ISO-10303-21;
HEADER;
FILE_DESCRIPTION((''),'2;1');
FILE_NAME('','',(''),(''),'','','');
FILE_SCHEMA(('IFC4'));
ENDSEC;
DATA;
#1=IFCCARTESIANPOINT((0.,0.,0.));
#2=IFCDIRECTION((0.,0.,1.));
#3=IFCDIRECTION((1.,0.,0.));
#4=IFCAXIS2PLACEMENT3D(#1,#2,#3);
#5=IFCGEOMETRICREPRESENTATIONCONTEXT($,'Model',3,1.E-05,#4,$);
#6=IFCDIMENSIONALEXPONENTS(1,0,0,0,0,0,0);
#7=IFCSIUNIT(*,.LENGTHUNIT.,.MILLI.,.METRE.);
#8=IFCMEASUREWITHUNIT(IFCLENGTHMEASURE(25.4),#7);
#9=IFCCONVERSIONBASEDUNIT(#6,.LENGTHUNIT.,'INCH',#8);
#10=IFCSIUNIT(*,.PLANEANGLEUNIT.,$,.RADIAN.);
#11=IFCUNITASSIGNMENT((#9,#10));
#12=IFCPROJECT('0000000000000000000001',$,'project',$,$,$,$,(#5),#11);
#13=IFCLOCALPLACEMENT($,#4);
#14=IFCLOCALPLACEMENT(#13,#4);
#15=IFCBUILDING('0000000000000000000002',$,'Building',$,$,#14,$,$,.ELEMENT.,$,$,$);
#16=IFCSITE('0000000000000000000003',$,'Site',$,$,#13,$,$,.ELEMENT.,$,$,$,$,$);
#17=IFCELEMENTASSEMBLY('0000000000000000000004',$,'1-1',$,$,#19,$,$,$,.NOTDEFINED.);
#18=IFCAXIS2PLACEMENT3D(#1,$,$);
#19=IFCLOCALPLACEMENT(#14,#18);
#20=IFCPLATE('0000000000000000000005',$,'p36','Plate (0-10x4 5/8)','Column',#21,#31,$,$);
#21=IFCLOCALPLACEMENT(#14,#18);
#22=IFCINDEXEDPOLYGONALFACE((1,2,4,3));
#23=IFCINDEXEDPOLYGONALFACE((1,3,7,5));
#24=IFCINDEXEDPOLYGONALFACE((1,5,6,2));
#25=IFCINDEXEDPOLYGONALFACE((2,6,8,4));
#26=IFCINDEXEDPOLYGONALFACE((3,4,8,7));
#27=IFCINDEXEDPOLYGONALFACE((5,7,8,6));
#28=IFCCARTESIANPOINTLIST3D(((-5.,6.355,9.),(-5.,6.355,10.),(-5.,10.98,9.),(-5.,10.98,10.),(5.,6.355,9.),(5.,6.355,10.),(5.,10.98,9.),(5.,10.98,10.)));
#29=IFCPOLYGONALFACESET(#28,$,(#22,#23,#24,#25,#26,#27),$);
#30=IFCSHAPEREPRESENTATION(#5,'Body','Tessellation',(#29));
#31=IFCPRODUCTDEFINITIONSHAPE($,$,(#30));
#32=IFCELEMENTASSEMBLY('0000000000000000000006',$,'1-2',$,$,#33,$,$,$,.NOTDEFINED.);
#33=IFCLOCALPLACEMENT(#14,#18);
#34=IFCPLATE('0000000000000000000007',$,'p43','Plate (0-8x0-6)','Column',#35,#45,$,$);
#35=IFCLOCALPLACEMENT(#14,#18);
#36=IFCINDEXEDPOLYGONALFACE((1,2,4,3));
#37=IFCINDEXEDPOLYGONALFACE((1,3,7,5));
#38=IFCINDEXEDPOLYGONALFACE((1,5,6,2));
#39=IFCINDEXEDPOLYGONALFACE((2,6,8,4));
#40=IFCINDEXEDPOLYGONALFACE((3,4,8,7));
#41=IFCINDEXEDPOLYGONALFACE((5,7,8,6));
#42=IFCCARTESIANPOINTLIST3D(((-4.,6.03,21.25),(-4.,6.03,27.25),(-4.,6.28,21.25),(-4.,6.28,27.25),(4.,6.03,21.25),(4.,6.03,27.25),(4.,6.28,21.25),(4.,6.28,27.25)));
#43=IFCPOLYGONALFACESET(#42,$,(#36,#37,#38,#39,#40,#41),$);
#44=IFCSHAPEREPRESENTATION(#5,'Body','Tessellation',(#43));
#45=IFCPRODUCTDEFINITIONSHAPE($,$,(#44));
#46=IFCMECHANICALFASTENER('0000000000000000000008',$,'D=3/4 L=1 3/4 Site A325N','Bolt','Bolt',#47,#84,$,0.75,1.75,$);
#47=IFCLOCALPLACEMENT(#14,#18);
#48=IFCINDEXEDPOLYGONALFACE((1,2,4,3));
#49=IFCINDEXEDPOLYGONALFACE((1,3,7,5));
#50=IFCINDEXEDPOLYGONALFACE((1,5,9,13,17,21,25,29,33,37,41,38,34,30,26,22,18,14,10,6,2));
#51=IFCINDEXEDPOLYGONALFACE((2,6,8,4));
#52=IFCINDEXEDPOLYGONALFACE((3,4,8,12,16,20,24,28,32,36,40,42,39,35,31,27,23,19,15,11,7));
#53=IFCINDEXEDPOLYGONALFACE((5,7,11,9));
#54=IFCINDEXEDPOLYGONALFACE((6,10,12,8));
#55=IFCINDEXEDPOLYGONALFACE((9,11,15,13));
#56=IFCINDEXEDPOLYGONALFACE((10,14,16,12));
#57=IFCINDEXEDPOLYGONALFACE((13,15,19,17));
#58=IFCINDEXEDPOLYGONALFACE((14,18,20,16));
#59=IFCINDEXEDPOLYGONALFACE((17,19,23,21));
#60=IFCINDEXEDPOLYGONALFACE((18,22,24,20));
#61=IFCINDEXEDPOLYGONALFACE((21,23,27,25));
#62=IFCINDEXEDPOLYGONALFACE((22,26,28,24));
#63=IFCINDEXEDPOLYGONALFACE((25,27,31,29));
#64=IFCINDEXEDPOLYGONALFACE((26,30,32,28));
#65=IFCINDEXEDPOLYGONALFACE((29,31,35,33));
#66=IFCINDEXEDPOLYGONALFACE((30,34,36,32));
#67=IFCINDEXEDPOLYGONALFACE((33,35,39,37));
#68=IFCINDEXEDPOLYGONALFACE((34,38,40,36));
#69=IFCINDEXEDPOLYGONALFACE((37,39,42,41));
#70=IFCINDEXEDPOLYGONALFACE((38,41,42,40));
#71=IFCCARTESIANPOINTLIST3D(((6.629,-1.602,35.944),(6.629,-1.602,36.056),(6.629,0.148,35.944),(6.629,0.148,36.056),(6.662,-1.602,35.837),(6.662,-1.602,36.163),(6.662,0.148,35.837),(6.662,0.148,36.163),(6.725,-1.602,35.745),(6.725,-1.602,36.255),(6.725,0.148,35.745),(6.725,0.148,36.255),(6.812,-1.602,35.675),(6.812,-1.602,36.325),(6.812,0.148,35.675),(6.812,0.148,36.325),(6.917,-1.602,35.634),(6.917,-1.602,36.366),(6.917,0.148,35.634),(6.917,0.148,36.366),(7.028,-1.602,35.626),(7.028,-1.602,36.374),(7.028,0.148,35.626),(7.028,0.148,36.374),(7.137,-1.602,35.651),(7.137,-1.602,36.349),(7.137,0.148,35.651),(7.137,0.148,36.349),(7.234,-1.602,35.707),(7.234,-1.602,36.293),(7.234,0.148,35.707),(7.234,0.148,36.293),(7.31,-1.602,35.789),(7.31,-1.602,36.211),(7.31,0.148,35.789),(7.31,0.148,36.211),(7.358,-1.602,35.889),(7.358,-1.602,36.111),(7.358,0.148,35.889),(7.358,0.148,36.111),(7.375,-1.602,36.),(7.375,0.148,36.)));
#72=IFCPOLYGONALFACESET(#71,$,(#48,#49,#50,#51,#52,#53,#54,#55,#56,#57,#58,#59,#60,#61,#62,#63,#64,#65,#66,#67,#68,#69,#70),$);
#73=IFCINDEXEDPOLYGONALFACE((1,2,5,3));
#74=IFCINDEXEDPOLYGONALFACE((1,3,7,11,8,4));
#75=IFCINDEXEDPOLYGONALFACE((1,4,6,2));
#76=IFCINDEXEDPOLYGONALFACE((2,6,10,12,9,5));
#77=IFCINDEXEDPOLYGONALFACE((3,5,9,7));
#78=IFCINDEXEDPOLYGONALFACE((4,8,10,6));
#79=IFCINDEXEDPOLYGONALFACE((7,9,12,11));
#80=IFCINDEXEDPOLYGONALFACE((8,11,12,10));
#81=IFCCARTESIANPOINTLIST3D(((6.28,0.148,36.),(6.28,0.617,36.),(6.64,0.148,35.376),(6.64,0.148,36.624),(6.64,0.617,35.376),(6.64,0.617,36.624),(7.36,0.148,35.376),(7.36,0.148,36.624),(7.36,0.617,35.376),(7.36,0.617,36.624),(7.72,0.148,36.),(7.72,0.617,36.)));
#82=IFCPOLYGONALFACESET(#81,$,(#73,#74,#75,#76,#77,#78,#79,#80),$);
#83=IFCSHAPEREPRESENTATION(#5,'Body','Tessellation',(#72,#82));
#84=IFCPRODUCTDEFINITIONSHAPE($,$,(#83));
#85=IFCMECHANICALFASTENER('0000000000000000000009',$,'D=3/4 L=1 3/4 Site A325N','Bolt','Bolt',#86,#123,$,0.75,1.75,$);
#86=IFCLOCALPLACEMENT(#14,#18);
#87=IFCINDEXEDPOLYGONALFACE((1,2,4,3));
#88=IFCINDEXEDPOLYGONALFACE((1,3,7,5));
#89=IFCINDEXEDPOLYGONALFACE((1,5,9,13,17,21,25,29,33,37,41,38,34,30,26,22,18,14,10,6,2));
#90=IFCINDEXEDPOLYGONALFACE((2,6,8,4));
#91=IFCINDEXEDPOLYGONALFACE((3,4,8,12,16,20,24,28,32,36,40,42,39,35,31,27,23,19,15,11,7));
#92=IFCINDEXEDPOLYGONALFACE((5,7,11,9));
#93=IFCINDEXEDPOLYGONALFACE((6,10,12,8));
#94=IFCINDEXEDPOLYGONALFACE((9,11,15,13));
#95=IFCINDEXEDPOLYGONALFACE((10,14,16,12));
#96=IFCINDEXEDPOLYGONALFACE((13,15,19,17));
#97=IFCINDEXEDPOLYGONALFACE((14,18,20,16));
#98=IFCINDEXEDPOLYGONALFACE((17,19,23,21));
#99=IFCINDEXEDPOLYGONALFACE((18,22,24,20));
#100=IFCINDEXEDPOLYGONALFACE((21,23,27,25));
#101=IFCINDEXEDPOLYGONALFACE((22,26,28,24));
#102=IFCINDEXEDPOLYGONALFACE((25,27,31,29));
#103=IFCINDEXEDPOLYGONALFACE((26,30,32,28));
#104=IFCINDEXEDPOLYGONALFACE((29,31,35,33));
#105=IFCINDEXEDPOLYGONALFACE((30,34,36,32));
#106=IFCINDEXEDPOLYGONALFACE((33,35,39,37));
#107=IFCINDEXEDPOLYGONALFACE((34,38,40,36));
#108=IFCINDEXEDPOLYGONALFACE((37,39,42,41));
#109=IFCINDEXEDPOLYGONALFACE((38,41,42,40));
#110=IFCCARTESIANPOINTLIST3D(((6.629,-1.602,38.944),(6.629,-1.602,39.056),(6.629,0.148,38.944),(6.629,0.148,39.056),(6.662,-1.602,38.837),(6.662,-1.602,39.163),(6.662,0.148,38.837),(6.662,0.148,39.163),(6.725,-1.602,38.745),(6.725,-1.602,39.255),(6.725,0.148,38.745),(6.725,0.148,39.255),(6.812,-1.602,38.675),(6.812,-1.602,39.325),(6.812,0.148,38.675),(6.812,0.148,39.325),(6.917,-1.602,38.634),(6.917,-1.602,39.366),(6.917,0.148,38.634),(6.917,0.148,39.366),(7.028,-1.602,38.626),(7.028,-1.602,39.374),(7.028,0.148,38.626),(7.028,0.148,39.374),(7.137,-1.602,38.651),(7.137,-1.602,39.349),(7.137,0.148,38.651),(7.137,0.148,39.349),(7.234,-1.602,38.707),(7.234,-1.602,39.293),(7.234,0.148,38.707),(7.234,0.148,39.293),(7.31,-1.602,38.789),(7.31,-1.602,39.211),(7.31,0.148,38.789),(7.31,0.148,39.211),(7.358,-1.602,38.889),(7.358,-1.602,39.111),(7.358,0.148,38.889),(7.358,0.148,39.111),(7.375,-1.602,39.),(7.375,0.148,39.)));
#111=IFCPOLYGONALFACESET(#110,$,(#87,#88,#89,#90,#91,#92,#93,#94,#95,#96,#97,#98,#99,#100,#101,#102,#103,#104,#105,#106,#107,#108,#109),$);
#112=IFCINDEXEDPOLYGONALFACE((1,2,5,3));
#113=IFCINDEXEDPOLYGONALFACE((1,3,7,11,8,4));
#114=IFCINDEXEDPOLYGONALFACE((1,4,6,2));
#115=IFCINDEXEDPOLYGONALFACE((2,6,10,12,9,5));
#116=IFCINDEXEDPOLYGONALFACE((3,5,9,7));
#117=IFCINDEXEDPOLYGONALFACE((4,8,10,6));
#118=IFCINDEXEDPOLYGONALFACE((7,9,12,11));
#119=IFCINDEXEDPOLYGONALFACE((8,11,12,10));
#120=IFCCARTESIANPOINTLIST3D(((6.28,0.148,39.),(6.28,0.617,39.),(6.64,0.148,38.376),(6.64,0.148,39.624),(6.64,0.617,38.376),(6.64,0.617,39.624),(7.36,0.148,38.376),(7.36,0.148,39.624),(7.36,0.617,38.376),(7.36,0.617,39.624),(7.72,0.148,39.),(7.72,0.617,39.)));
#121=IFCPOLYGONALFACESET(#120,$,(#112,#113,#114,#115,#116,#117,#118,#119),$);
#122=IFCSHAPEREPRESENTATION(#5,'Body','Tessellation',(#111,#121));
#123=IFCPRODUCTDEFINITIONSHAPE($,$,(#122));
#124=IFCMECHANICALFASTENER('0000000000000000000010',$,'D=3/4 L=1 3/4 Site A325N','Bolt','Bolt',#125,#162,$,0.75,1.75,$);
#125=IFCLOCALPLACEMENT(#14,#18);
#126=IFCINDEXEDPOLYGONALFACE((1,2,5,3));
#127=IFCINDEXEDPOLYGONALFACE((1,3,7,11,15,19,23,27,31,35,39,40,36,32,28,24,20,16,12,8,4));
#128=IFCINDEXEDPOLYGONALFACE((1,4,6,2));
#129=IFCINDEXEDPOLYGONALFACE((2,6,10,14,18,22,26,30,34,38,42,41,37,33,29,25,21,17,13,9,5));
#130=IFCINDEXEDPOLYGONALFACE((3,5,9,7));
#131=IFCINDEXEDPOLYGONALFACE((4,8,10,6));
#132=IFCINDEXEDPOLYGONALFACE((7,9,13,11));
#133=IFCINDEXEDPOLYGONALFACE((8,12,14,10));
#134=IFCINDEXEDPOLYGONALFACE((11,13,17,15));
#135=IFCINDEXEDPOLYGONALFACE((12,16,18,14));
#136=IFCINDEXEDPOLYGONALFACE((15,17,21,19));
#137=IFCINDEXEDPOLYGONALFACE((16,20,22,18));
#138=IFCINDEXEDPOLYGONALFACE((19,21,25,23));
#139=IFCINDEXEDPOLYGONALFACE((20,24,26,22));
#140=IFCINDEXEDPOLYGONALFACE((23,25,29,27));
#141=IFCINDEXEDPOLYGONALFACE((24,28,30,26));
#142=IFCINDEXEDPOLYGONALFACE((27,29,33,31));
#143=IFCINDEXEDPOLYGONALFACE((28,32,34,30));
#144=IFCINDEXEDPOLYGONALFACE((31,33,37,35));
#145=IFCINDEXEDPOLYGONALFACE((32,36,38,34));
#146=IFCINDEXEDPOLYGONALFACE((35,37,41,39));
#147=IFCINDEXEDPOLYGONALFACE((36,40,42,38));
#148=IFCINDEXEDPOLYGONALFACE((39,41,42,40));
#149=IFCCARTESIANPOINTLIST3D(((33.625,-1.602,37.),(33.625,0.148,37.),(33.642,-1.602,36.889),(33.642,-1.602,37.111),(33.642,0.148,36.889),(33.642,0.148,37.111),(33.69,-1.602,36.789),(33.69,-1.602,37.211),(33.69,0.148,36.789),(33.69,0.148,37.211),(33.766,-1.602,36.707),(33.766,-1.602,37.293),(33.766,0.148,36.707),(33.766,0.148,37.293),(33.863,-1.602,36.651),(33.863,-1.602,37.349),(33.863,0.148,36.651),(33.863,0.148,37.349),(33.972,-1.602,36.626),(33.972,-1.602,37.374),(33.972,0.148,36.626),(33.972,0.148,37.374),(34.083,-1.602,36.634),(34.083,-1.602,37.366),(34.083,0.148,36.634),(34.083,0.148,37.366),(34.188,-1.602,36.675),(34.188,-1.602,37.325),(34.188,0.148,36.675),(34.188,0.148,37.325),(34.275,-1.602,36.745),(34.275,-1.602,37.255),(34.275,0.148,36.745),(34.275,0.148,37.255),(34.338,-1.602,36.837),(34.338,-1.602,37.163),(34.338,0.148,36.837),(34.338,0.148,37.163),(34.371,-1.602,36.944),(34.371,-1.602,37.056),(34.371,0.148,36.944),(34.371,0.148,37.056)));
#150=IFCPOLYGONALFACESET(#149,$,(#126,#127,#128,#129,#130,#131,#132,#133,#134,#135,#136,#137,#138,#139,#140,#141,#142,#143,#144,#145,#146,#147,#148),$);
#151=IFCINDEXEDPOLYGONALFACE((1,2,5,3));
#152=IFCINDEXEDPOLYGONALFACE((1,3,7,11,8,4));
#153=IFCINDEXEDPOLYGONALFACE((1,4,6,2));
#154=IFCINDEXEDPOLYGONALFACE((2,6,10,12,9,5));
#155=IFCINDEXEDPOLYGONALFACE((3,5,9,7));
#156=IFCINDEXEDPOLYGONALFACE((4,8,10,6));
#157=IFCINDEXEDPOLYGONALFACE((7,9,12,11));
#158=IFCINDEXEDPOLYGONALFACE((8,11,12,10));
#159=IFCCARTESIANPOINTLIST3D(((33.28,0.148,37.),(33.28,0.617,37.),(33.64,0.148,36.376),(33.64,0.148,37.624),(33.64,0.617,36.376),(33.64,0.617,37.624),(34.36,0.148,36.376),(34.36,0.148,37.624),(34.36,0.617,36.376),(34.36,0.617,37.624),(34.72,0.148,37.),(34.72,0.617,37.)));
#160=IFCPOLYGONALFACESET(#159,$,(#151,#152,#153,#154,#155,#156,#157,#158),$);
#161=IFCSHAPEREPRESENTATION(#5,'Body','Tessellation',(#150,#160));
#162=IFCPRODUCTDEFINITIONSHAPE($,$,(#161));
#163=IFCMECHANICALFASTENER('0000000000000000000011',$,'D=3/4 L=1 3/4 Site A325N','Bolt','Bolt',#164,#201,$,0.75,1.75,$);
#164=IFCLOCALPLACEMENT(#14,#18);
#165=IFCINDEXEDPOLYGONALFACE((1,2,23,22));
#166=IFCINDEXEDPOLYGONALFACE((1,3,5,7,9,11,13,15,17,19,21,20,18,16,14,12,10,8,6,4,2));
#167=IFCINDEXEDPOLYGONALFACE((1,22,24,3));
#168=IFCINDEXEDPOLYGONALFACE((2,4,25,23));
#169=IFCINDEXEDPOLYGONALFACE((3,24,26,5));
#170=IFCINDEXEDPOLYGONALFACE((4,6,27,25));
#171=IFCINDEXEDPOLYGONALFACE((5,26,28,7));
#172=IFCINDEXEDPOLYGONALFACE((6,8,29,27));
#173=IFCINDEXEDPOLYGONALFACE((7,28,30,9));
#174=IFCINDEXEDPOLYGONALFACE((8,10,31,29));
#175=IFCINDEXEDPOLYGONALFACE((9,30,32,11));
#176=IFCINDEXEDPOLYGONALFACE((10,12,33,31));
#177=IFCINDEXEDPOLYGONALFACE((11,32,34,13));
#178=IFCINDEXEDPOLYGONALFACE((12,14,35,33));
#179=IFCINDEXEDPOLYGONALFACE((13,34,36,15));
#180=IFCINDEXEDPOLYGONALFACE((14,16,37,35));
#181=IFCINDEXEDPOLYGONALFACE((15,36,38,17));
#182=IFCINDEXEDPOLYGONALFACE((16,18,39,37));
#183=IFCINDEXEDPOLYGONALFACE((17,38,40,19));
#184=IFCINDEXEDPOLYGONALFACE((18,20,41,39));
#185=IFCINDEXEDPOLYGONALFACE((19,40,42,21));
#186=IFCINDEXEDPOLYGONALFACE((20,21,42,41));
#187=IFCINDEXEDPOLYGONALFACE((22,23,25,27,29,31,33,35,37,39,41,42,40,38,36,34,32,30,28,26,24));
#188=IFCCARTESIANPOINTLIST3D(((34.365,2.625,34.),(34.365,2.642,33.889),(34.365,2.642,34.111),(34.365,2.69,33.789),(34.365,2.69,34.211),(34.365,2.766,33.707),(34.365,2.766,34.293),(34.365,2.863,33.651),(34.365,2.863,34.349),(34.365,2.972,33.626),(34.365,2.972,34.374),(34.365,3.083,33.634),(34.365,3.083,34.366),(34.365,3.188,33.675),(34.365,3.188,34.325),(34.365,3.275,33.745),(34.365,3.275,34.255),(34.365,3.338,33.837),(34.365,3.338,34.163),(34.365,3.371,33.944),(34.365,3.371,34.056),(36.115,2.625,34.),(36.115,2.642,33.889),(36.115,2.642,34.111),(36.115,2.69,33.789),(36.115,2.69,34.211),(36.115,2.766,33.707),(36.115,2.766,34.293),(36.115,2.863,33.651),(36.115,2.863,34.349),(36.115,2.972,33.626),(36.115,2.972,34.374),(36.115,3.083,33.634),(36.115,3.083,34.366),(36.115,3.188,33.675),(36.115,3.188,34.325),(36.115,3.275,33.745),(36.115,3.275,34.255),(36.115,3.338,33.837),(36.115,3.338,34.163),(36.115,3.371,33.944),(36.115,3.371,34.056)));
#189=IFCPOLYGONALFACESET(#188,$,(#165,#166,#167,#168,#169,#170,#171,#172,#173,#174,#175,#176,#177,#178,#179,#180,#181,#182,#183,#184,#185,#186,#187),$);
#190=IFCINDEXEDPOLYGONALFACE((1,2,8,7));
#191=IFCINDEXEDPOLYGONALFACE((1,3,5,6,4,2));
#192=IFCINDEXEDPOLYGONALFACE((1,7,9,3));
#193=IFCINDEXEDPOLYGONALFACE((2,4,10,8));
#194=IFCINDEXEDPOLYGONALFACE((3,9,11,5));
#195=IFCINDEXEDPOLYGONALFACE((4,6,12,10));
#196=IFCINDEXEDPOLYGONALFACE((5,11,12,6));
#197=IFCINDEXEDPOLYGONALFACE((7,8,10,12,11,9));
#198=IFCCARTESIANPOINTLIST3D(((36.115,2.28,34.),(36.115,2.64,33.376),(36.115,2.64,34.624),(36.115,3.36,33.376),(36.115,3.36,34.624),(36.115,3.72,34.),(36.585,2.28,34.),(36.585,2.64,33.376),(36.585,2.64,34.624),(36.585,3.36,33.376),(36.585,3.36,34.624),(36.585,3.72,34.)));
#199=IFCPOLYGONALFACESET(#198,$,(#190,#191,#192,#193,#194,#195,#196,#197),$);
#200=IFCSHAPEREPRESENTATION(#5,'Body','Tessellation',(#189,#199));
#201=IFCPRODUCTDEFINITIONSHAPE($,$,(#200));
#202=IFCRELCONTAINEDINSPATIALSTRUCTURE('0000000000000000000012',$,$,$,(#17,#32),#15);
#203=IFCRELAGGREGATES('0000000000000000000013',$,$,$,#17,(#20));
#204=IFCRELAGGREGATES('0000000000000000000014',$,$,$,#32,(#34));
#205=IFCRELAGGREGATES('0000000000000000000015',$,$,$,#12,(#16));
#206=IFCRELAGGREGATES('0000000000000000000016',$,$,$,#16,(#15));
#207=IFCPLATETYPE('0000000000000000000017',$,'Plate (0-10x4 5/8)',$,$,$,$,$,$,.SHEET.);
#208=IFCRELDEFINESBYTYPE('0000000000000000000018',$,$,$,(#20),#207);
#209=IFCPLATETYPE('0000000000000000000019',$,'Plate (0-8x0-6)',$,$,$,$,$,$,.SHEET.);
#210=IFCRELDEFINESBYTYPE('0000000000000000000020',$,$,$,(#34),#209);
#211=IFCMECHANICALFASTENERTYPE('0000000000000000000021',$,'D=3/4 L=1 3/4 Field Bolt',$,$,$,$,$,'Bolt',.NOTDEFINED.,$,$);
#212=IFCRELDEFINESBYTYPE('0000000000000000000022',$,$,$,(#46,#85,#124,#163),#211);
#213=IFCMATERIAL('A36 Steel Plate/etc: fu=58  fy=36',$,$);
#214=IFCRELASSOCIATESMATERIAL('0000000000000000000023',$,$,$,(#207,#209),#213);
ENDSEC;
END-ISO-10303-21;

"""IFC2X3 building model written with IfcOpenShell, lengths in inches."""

from ifc_helpers import new_model, entity, si_unit, converted_unit, frame, origin_with_axes, origin_2d_with_axis, place, context, project, spatial, polyline, circle, outline, extrude, source, transform, mapped, material, type_object, type_shapes, element, aggregate, save


model = new_model("IFC2X3")

# Units and contexts
model_context = context("Model", 3, precision=1e-05, world=origin_with_axes())
ifc_project = project(units=[converted_unit("LENGTHUNIT", "INCH", entity("IfcLengthMeasure", 25.4), si_unit("LENGTHUNIT", "METRE", prefix="MILLI"), dimensions=[1, 0, 0, 0, 0, 0, 0]), si_unit("PLANEANGLEUNIT", "RADIAN")], contexts=[model_context])

# Site, building
site_placement = place(None, origin_with_axes())
site = spatial("IfcSite", under=ifc_project, at=site_placement, Name="Site", CompositionType="ELEMENT")
building_placement = place(site_placement, origin_with_axes())
building = spatial("IfcBuilding", under=site, at=building_placement, Name="Building", CompositionType="ELEMENT")

# Shared definitions
ifc_material = material(Name="A36 Steel Plate/etc: fu=58  fy=36")

# Element assemblies, plates
assembly_1_placement = place(building_placement, frame((0.0, 0.0, -1.5), z_axis=(0.0, -1.0, 0.0), x_axis=(0.0, 0.0, 1.0)))
assembly_1 = element("IfcElementAssembly", 1, at=assembly_1_placement, inside=building, Name="1-1", PredefinedType="NOTDEFINED")
plate_type_1 = type_object("IfcPlateType", Name="Plate (0-10x4 5/8)", PredefinedType="SHEET", material=ifc_material)
shared_shape_1 = source(origin_with_axes(), model_context, "Body", "SweptSolid", [
    extrude(outline(polyline([(0.0, -10.0), (-4.625, -10.0), (-4.625, 0.0), (0.0, 0.0), (0.0, -10.0)])), frame((-0.5, 0.0, 0.0), z_axis=(1.0, 0.0, 0.0), x_axis=(0.0, 1.0, 0.0)), (0.0, 0.0, 1.0), 1.0),
])
type_shapes(plate_type_1, [shared_shape_1])
plate_1_placement = place(assembly_1_placement, frame((11.0, -5.0, -6.355), z_axis=(0.0, -1.0, 0.0), x_axis=(1.0, 0.0, 0.0)))
plate_1 = element("IfcPlate", 2, at=plate_1_placement, type_object=plate_type_1, Name="p36", Description="Plate (0-10x4 5/8)", ObjectType="Column", context=model_context, shape_type="MappedRepresentation", body=[
    mapped(shared_shape_1, transform((0.0, 0.0, 0.0), scale=1.0)),
])
aggregate(assembly_1, [plate_1])
assembly_2_placement = place(building_placement, frame((0.0, 0.0, 21.0), z_axis=(0.0, -1.0, 0.0), x_axis=(0.0, 0.0, 1.0)))
assembly_2 = element("IfcElementAssembly", 3, at=assembly_2_placement, inside=building, Name="1-2", PredefinedType="NOTDEFINED")
plate_type_2 = type_object("IfcPlateType", Name="Plate (0-8x0-6)", PredefinedType="SHEET", material=ifc_material)
shared_shape_2 = source(origin_with_axes(), model_context, "Body", "SweptSolid", [
    extrude(outline(polyline([(0.0, -8.0), (-6.0, -8.0), (-6.0, 0.0), (0.0, 0.0), (0.0, -8.0)])), frame((-0.125, 0.0, 0.0), z_axis=(1.0, 0.0, 0.0), x_axis=(0.0, 1.0, 0.0)), (0.0, 0.0, 1.0), 0.25),
])
type_shapes(plate_type_2, [shared_shape_2])
plate_2_placement = place(assembly_2_placement, frame((6.25, -4.0, -6.155), z_axis=(0.0, -1.0, 0.0), x_axis=(0.0, 0.0, -1.0)))
plate_2 = element("IfcPlate", 4, at=plate_2_placement, type_object=plate_type_2, Name="p43", Description="Plate (0-8x0-6)", ObjectType="Column", context=model_context, shape_type="MappedRepresentation", body=[
    mapped(shared_shape_2, transform((0.0, 0.0, 0.0), scale=1.0)),
])
aggregate(assembly_2, [plate_2])

# Mechanical fasteners
mechanical_fastener_type_1 = type_object("IfcMechanicalFastenerType", Name="D=3/4 L=1 3/4 Field Bolt", ElementType="Bolt")
shared_shape_3 = source(origin_with_axes(), model_context, "Body", "SweptSolid", [
    extrude(circle(Radius=0.375, at=origin_2d_with_axis()), frame((0.0, 0.0, 0.0), z_axis=(1.0, 0.0, 0.0), x_axis=(0.0, 1.0, 0.0)), (0.0, 0.0, 1.0), 1.75),
    extrude(outline(polyline([(-0.72, 0.0), (-0.36, 0.624), (0.36, 0.624), (0.72, 0.0), (0.36, -0.624), (-0.36, -0.624), (-0.72, 0.0)])), frame((0.0, 0.0, 0.0), z_axis=(1.0, 0.0, 0.0), x_axis=(0.0, 1.0, 0.0)), (0.0, 0.0, -1.0), 0.47),
])
type_shapes(mechanical_fastener_type_1, [shared_shape_3])
placement_1 = place(building_placement, frame((0.0, 0.0, 46.0), z_axis=(0.0, 0.0, 1.0), x_axis=(1.0, 0.0, 0.0)))
placement_2 = place(placement_1, frame((7.0, 0.148, -4.0), z_axis=(0.0, 0.0, 1.0), x_axis=(0.0, -1.0, 0.0)))
for number, where, z_axis, x_axis, name in (
    (5, (0.0, 0.0, -6.0), (0.0, 0.0, 1.0), (1.0, 0.0, 0.0), "D=3/4 L=1 3/4 Site A325N"),
    (6, (0.0, 0.0, -3.0), (0.0, 0.0, 1.0), (1.0, 0.0, 0.0), "D=3/4 L=1 3/4 Site A325N"),
):
    element("IfcMechanicalFastener", number, at=place(placement_2, frame(where, z_axis=z_axis, x_axis=x_axis)), type_object=mechanical_fastener_type_1, Name=name, Description="Bolt", ObjectType="Bolt", NominalDiameter=0.75, NominalLength=1.75, context=model_context, shape_type="MappedRepresentation", body=[
        mapped(shared_shape_3, transform((0.0, 0.0, 0.0), scale=1.0)),
    ])
placement_3 = place(building_placement, frame((36.0, 0.0, 46.0), z_axis=(0.0, 0.0, 1.0), x_axis=(0.0, -1.0, 0.0)))
placement_4 = place(placement_3, frame((-0.148, -2.0, -3.0), z_axis=(0.0, 0.0, -1.0), x_axis=(1.0, 0.0, 0.0)))
for number, where, z_axis, x_axis, name in (
    (7, (0.0, 0.0, 6.0), (0.0, 0.0, 1.0), (1.0, 0.0, 0.0), "D=3/4 L=1 3/4 Site A325N"),
):
    element("IfcMechanicalFastener", number, at=place(placement_4, frame(where, z_axis=z_axis, x_axis=x_axis)), type_object=mechanical_fastener_type_1, Name=name, Description="Bolt", ObjectType="Bolt", NominalDiameter=0.75, NominalLength=1.75, context=model_context, shape_type="MappedRepresentation", body=[
        mapped(shared_shape_3, transform((0.0, 0.0, 0.0), scale=1.0)),
    ])
placement_5 = place(building_placement, frame((36.0, 0.0, 43.0), z_axis=(0.0, 0.0, 1.0), x_axis=(0.0, 1.0, 0.0)))
placement_6 = place(placement_5, frame((3.0, -0.115, -3.0), z_axis=(0.0, 0.0, 1.0), x_axis=(0.0, 1.0, 0.0)))
for number, where, z_axis, x_axis, name in (
    (8, (0.0, 0.0, -6.0), (0.0, 0.0, 1.0), (1.0, 0.0, 0.0), "D=3/4 L=1 3/4 Site A325N"),
):
    element("IfcMechanicalFastener", number, at=place(placement_6, frame(where, z_axis=z_axis, x_axis=x_axis)), type_object=mechanical_fastener_type_1, Name=name, Description="Bolt", ObjectType="Bolt", NominalDiameter=0.75, NominalLength=1.75, context=model_context, shape_type="MappedRepresentation", body=[
        mapped(shared_shape_3, transform((0.0, 0.0, 0.0), scale=1.0)),
    ])

save(model, "model.ifc")
